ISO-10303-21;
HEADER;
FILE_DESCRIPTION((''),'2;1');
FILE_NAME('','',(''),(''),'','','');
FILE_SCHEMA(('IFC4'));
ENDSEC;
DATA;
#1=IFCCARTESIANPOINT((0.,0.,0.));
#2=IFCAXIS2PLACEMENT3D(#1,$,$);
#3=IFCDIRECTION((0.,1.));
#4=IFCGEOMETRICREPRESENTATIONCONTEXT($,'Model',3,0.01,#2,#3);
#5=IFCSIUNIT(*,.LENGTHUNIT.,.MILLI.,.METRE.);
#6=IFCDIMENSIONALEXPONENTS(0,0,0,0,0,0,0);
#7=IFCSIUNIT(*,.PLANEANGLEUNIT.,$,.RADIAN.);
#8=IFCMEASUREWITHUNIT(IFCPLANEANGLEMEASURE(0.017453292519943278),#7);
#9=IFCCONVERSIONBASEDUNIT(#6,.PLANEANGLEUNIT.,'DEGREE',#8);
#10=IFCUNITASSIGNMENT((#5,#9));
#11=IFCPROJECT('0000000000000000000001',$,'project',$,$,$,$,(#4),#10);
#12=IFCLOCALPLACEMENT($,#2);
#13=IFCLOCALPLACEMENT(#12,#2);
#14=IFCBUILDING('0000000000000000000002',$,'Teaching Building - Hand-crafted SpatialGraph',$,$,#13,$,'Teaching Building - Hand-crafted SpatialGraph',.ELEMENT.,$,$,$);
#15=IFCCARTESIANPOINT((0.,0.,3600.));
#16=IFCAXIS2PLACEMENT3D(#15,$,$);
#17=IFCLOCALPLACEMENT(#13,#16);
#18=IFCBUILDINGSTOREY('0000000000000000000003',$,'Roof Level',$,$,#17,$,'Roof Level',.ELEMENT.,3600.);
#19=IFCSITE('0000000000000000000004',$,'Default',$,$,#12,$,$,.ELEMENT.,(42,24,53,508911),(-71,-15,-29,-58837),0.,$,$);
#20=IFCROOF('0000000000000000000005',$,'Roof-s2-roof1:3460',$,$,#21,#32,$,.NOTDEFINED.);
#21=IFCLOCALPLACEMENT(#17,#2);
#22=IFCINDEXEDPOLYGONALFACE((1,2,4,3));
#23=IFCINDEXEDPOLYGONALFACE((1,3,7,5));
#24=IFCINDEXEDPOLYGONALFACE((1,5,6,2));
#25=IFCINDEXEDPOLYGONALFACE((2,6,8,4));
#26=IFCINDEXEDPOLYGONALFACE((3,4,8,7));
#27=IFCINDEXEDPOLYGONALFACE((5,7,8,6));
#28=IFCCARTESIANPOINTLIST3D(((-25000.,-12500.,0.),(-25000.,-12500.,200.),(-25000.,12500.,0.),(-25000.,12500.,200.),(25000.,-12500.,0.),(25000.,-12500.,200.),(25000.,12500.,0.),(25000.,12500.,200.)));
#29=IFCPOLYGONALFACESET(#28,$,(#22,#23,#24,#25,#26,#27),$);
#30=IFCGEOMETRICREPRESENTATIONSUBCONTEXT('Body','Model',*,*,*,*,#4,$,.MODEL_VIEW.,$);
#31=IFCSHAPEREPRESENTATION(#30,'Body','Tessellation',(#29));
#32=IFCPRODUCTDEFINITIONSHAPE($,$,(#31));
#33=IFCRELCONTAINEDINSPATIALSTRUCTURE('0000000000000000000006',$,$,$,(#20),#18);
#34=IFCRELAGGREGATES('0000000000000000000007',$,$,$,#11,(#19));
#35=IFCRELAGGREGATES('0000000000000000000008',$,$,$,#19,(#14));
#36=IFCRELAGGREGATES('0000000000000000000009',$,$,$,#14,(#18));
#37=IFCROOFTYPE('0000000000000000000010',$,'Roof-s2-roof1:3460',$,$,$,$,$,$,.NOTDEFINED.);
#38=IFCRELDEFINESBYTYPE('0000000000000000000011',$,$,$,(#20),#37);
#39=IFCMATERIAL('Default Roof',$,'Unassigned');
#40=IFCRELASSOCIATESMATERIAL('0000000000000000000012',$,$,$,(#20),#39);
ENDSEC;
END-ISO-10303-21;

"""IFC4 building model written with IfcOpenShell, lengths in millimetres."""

from ifc_helpers import new_model, entity, si_unit, converted_unit, direction, frame, origin, origin_2d_with_axis, place, context, subcontext, project, spatial, rectangle, extrude, material, type_object, element, save


model = new_model("IFC4")

# Units and contexts
model_context = context("Model", 3, precision=0.01, world=origin(), true_north=direction((0.0, 1.0)))
body_context = subcontext(model_context, "Body", "Model", "MODEL_VIEW")
ifc_project = project(units=[si_unit("LENGTHUNIT", "METRE", prefix="MILLI"), converted_unit("PLANEANGLEUNIT", "DEGREE", entity("IfcPlaneAngleMeasure", 0.017453292519943278), si_unit("PLANEANGLEUNIT", "RADIAN"), dimensions=[0, 0, 0, 0, 0, 0, 0])], contexts=[model_context])

# Site, building, storey
site_placement = place(None, origin())
site = spatial("IfcSite", under=ifc_project, at=site_placement, Name="Default", CompositionType="ELEMENT", RefLatitude=(42, 24, 53, 508911), RefLongitude=(-71, -15, -29, -58837), RefElevation=0.0)
building_placement = place(site_placement, origin())
building = spatial("IfcBuilding", under=site, at=building_placement, Name="Teaching Building - Hand-crafted SpatialGraph", LongName="Teaching Building - Hand-crafted SpatialGraph", CompositionType="ELEMENT")
storey_placement = place(building_placement, frame((0.0, 0.0, 3600.0)))
storey = spatial("IfcBuildingStorey", under=building, at=storey_placement, Name="Roof Level", LongName="Roof Level", CompositionType="ELEMENT", Elevation=3600.0)

# Roof
ifc_material = material(Name="Default Roof", Category="Unassigned")
roof_type = type_object("IfcRoofType", Name="Roof-s2-roof1:3460", PredefinedType="NOTDEFINED")
roof_placement = place(storey_placement, origin())
element("IfcRoof", 1, at=roof_placement, inside=storey, type_object=roof_type, material=ifc_material, Name="Roof-s2-roof1:3460", PredefinedType="NOTDEFINED", context=body_context, shape_type="SweptSolid", body=[
    extrude(rectangle(XDim=50000.0, YDim=25000.0, at=origin_2d_with_axis()), origin(), (0.0, 0.0, 1.0), 200.0),
])

save(model, "model.ifc")
